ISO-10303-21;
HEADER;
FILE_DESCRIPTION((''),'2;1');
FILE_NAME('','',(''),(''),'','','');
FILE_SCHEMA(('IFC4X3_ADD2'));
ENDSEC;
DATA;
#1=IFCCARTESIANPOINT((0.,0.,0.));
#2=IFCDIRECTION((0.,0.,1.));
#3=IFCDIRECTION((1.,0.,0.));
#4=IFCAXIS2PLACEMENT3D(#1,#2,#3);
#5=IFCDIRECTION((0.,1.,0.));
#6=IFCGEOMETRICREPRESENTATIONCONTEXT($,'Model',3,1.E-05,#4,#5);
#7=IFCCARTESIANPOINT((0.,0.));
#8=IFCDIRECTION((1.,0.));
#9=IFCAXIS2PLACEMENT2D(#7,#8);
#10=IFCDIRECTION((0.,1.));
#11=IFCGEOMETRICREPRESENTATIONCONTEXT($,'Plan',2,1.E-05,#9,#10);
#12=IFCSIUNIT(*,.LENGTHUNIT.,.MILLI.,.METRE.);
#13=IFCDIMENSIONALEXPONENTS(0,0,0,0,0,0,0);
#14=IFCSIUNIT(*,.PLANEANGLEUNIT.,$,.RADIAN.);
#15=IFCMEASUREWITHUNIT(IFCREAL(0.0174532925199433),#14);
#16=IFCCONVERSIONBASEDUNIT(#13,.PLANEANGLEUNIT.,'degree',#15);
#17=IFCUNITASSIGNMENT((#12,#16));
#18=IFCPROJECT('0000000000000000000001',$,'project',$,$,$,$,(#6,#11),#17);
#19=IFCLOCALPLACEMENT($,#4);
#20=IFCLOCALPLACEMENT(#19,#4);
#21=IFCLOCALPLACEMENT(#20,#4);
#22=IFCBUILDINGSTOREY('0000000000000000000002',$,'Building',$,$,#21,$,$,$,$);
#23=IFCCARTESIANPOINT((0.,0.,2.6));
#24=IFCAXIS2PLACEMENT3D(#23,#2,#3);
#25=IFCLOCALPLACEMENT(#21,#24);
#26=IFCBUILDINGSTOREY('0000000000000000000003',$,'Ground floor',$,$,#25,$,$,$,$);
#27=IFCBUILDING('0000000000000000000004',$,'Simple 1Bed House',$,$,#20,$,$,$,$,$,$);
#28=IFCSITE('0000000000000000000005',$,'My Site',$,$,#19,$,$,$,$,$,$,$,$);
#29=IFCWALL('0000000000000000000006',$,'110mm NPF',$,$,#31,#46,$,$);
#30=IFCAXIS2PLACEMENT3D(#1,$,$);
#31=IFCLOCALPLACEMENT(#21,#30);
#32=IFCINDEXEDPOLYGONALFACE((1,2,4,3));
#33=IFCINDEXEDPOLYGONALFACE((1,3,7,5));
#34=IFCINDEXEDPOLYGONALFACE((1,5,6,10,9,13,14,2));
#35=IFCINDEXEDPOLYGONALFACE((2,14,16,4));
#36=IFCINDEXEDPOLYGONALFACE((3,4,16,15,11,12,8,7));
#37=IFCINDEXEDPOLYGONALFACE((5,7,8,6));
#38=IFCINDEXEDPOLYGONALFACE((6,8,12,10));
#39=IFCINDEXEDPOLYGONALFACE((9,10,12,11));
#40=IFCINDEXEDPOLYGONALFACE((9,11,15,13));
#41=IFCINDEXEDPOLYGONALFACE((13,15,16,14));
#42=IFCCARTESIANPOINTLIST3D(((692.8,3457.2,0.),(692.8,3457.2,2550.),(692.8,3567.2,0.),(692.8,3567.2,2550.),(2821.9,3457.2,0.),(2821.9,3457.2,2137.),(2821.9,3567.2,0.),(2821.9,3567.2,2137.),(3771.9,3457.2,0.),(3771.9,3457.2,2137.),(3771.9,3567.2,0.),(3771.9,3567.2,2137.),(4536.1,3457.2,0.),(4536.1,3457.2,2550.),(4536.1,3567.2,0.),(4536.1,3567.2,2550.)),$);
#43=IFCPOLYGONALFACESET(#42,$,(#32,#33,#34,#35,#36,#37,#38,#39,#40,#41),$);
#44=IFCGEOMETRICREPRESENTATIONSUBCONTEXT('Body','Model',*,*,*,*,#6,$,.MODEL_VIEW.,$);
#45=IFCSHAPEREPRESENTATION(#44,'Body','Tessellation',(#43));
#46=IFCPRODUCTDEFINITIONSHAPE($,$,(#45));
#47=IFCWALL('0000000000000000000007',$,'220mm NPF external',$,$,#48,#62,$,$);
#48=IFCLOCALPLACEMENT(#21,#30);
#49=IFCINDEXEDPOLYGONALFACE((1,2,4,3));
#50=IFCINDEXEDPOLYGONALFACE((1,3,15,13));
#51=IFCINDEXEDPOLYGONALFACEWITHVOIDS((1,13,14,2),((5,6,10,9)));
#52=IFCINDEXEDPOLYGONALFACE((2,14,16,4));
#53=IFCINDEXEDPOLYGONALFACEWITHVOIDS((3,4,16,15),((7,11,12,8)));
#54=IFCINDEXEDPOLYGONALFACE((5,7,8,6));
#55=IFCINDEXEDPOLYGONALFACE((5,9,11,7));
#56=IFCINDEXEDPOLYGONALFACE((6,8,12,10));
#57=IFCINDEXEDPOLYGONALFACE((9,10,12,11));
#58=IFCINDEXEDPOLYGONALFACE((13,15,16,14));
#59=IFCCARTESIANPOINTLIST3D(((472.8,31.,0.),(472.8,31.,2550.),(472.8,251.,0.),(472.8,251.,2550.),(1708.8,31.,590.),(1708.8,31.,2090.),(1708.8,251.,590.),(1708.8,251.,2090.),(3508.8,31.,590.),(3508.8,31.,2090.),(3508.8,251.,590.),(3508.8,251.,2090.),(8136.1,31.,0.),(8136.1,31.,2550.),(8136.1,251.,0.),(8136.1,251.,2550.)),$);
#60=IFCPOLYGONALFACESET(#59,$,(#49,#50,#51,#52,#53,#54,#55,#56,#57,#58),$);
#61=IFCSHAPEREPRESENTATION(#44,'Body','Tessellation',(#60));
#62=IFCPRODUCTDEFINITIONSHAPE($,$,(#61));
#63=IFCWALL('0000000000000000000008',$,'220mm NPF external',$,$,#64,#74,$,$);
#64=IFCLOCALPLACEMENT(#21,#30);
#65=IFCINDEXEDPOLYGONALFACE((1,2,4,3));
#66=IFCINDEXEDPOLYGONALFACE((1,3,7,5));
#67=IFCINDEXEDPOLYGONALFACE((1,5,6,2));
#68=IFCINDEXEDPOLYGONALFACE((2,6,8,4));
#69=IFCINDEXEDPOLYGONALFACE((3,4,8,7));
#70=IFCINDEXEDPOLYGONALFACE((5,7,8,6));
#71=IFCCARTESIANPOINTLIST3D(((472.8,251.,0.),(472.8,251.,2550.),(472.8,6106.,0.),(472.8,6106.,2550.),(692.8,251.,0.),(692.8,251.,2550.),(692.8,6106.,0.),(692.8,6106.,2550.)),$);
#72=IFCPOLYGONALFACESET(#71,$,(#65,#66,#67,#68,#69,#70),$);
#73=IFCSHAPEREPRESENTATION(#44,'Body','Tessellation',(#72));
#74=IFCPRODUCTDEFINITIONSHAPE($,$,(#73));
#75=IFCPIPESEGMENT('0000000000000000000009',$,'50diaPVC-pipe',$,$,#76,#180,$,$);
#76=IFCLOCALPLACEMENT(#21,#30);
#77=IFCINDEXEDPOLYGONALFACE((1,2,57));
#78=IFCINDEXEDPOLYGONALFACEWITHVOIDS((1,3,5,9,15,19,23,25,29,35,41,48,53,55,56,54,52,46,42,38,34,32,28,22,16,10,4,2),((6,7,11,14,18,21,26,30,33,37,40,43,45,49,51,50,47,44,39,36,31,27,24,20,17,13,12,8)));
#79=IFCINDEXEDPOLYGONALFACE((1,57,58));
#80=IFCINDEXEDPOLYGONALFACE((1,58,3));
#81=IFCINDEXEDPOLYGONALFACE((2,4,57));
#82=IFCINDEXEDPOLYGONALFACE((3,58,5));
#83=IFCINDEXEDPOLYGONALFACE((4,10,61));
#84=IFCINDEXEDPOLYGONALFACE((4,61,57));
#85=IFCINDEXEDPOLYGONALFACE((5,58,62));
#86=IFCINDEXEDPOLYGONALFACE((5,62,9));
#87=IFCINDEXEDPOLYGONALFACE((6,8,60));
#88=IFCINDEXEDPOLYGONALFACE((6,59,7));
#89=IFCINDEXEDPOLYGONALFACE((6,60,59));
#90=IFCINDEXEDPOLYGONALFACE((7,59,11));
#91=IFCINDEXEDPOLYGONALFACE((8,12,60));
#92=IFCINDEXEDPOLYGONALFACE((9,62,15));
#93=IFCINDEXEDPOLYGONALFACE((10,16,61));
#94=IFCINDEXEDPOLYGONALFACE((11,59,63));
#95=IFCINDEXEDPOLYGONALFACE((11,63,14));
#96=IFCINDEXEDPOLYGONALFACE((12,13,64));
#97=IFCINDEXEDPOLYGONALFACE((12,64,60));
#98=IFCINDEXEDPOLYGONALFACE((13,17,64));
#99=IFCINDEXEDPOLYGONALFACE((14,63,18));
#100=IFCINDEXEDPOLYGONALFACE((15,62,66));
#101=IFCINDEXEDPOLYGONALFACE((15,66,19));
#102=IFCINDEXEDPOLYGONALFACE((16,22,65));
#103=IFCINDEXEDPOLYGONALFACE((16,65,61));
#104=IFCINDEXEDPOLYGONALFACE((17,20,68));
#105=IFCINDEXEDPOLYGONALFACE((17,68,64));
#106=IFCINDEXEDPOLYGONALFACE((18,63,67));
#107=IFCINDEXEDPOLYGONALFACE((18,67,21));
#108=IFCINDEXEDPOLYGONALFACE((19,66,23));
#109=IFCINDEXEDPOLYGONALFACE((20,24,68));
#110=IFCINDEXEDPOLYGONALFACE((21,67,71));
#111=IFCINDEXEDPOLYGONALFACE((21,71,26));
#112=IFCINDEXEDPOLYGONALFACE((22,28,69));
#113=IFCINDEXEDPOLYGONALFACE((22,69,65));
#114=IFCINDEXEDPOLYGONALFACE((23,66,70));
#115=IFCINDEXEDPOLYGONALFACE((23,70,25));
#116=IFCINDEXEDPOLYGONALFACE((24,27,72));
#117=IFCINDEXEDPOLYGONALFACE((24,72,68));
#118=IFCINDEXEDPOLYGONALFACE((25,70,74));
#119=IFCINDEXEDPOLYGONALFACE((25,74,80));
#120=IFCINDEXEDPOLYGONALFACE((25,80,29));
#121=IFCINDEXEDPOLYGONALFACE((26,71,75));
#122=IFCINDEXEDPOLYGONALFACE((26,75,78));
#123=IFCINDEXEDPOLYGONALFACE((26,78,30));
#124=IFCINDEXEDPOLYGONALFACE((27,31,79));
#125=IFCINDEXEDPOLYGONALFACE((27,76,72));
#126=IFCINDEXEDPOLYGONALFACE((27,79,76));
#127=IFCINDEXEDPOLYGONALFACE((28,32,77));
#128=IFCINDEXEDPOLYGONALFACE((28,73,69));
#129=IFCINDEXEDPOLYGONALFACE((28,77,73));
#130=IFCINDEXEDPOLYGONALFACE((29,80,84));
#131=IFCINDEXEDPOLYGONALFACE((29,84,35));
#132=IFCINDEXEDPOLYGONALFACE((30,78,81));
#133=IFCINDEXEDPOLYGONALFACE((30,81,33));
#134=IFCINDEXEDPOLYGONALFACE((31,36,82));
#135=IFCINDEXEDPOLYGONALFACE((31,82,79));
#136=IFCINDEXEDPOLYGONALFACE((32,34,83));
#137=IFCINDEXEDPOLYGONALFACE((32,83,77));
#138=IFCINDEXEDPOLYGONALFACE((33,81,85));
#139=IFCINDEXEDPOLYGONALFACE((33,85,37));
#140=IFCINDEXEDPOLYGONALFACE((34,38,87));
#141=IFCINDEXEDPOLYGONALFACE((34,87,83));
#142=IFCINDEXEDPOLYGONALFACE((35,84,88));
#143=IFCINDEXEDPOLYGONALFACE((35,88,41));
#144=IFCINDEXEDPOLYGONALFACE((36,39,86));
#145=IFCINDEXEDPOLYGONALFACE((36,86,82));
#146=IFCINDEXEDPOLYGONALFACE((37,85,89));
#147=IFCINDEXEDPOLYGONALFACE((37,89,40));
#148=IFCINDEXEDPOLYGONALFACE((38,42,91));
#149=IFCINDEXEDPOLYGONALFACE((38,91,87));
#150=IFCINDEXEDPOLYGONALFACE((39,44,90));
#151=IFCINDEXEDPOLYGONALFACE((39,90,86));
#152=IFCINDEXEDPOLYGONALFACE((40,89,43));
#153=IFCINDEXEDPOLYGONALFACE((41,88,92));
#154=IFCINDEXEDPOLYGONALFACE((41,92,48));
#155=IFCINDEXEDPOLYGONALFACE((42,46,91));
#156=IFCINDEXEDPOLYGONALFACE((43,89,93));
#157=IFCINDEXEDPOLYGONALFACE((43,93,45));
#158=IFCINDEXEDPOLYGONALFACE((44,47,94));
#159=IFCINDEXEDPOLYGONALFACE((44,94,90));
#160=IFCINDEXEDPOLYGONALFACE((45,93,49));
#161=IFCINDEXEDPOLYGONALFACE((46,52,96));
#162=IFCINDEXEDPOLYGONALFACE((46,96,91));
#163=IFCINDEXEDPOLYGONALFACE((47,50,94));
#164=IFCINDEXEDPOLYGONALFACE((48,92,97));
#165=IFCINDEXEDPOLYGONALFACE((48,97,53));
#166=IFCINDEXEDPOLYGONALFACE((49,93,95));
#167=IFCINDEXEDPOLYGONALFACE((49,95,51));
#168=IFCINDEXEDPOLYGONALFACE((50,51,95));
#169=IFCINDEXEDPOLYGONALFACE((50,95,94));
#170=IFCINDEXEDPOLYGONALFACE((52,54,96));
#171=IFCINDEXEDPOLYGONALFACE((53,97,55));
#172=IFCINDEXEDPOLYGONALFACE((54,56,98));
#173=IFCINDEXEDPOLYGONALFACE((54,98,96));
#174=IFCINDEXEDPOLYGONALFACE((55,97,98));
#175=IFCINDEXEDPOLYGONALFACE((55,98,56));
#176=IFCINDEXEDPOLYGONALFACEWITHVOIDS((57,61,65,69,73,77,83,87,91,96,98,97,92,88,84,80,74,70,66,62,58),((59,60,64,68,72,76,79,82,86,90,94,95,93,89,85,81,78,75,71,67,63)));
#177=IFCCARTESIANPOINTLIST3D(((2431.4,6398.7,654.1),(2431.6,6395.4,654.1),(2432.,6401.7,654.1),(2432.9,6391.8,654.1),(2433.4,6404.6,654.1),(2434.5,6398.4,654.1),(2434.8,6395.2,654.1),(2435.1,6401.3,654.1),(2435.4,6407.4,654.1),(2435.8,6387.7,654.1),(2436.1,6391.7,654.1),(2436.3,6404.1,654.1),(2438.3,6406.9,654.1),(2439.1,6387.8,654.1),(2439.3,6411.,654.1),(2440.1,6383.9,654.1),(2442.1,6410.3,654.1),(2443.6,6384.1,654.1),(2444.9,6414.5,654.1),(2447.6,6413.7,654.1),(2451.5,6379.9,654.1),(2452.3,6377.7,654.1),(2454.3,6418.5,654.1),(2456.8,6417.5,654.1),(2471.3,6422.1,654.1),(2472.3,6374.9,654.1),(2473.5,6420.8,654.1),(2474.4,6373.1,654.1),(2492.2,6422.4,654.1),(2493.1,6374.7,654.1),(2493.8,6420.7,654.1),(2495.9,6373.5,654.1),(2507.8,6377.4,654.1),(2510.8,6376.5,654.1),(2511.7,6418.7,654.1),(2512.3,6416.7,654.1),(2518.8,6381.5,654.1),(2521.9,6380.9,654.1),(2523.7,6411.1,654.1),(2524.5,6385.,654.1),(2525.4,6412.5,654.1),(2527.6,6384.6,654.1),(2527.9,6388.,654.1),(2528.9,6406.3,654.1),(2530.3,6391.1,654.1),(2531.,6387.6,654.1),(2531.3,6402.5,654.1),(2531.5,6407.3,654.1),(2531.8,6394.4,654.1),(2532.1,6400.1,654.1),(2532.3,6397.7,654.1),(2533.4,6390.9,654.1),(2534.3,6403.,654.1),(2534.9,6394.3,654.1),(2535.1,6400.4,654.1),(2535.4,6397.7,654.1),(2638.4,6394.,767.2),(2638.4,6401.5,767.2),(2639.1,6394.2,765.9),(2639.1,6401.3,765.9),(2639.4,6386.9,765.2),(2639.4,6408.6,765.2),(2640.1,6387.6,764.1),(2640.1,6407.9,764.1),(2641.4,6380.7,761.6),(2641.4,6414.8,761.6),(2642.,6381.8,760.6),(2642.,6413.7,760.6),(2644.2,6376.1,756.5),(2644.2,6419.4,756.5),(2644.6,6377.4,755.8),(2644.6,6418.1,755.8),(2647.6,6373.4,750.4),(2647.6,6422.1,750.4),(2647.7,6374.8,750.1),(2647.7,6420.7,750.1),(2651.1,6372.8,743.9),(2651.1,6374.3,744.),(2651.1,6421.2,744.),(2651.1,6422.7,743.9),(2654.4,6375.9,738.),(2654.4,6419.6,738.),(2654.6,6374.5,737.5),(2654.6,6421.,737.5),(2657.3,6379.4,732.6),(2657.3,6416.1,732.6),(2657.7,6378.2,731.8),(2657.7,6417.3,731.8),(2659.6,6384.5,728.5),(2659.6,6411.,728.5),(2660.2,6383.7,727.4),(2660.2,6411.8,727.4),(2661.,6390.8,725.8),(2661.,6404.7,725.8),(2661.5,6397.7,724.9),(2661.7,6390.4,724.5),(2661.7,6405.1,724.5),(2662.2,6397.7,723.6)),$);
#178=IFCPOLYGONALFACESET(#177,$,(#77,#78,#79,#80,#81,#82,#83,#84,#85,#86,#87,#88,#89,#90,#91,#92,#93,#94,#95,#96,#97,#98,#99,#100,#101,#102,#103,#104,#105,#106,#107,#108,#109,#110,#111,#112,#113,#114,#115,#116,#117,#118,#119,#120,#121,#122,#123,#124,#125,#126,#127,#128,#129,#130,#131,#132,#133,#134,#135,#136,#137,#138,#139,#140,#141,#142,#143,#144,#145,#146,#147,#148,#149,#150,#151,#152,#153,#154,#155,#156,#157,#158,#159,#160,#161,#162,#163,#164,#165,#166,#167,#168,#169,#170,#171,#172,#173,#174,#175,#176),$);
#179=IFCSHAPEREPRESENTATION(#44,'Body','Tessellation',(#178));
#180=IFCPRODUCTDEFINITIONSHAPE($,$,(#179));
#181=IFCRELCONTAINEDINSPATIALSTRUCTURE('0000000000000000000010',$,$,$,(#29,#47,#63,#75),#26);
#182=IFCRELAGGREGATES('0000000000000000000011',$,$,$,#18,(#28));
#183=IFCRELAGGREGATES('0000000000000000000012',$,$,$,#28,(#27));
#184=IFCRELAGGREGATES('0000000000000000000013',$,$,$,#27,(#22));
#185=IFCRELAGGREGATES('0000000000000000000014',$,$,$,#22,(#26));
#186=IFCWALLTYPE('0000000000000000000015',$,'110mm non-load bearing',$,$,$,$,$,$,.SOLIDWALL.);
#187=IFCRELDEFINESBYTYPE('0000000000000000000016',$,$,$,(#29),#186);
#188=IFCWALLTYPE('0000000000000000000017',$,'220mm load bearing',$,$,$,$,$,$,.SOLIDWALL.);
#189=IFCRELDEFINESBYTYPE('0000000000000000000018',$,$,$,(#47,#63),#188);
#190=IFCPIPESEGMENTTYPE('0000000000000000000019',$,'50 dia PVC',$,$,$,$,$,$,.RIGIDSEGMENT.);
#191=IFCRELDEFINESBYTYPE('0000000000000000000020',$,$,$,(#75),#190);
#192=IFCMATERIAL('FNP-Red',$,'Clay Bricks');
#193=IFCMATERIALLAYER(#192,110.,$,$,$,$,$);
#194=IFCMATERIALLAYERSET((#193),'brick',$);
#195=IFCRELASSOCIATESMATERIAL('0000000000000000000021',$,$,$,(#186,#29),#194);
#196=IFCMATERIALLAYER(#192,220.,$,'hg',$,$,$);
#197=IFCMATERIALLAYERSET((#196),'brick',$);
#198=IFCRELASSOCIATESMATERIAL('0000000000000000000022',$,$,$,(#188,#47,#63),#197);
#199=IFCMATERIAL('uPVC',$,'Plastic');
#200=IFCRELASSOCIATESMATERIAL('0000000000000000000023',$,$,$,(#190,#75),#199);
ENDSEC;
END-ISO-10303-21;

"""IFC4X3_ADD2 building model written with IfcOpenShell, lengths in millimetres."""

from ifc_helpers import new_model, entity, si_unit, converted_unit, direction, frame, origin_with_axes, origin_2d_with_axis, place, context, subcontext, project, spatial, line, indexed_curve, hollow_circle, outline, extrude, clip, halfspace, source, transform, mapped, material, layer, layer_set, layer_usage, material_profile, profile_set, profile_usage, type_object, element, save


model = new_model("IFC4X3_ADD2")

# Units and contexts
model_context = context("Model", 3, precision=1e-05, world=origin_with_axes(), true_north=direction((0.0, 1.0, 0.0)))
plan_context = context("Plan", 2, precision=1e-05, world=origin_2d_with_axis(), true_north=direction((0.0, 1.0)))
body_context_1 = subcontext(model_context, "Body", "Model", "MODEL_VIEW")
ifc_project = project(units=[si_unit("LENGTHUNIT", "METRE", prefix="MILLI"), converted_unit("PLANEANGLEUNIT", "degree", entity("IfcReal", 0.0174532925199433), si_unit("PLANEANGLEUNIT", "RADIAN"), dimensions=[0, 0, 0, 0, 0, 0, 0])], contexts=[model_context, plan_context])

# Site, building, storeys
site_placement = place(None, origin_with_axes())
site = spatial("IfcSite", under=ifc_project, at=site_placement, Name="My Site")
building_placement = place(site_placement, origin_with_axes())
building = spatial("IfcBuilding", under=site, at=building_placement, Name="Simple 1Bed House")
storey_1_placement = place(building_placement, origin_with_axes())
storey_1 = spatial("IfcBuildingStorey", under=building, at=storey_1_placement, Name="Building")
storey_2_placement = place(storey_1_placement, frame((0.0, 0.0, 2.6), z_axis=(0.0, 0.0, 1.0), x_axis=(1.0, 0.0, 0.0)))
storey_2 = spatial("IfcBuildingStorey", under=storey_1, at=storey_2_placement, Name="Ground floor")

# Walls, openings
ifc_material_1 = material(Name="FNP-Red", Category="Clay Bricks")
ifc_layer_1 = layer(ifc_material_1, 110.0)
ifc_layer_set_1 = layer_set([ifc_layer_1], Name="brick")
ifc_layer_usage_1 = layer_usage(ifc_layer_set_1, "AXIS2", "POSITIVE", 0.0)
wall_type_1 = type_object("IfcWallType", Name="110mm non-load bearing", PredefinedType="SOLIDWALL", material=ifc_layer_set_1)
wall_1_placement = place(storey_2_placement, frame((692.8, 3457.2, -2.6), z_axis=(0.0, 0.0, 1.0), x_axis=(1.0, 0.000001, 0.0)))
wall_1 = element("IfcWall", 1, at=wall_1_placement, inside=storey_2, type_object=wall_type_1, material=ifc_layer_usage_1, Name="110mm NPF", context=body_context_1, shape_type="SweptSolid", body=[
    extrude(outline(indexed_curve([(0.0, 0.0), (0.0, 110.0), (3843.3, 110.0), (3843.3, 0.0), (0.0, 0.0)], self_intersect=False)), origin_with_axes(), (0.0, 0.0, 1.0), 2550.0),
])
shared_shape_1 = source(origin_with_axes(), body_context_1, "Body", "SweptSolid", [
    extrude(outline(indexed_curve([(0.0, 2137.0), (0.0, 0.0), (950.0, 0.0), (950.0, 2137.0), (0.0, 2137.0)])), frame((0.0, -600.0, 0.0), z_axis=(0.0, -1.0, 0.0), x_axis=(1.0, 0.0, 0.0)), (0.0, 0.0, -1.0), 1200.0),
])
opening_1_placement = place(wall_1_placement, frame((3079.1, 120.0, 0.0), z_axis=(0.0, 0.0, 1.0), x_axis=(-1.0, 0.0, 0.0)))
element("IfcOpeningElement", 2, at=opening_1_placement, cuts=wall_1, PredefinedType="OPENING", context=body_context_1, shape_type="MappedRepresentation", body=[
    mapped(shared_shape_1, transform((0.0, 0.0, 0.0), x_axis=(1.0, 0.0, 0.0), y_axis=(0.0, 1.0, 0.0), z_axis=(0.0, 0.0, 1.0), scale=1.0)),
])
ifc_layer_2 = layer(ifc_material_1, 220.0, Name="hg")
ifc_layer_set_2 = layer_set([ifc_layer_2], Name="brick")
ifc_layer_usage_2 = layer_usage(ifc_layer_set_2, "AXIS2", "POSITIVE", 0.0)
wall_type_2 = type_object("IfcWallType", Name="220mm load bearing", PredefinedType="SOLIDWALL", material=ifc_layer_set_2)
wall_2_placement = place(storey_2_placement, frame((472.8, 31.0, -2.6), z_axis=(0.0, 0.0, 1.0), x_axis=(1.0, 0.0, 0.0)))
wall_2 = element("IfcWall", 3, at=wall_2_placement, inside=storey_2, type_object=wall_type_2, material=ifc_layer_usage_2, Name="220mm NPF external", context=body_context_1, shape_type="SweptSolid", body=[
    extrude(outline(indexed_curve([(0.0, 0.0), (0.0, 220.0), (7663.3, 220.0), (7663.3, 0.0), (0.0, 0.0)], self_intersect=False)), origin_with_axes(), (0.0, 0.0, 1.0), 2550.0),
])
shared_shape_2 = source(origin_with_axes(), body_context_1, "Body", "SweptSolid", [
    extrude(outline(indexed_curve([(0.0, 0.0), (1800.0, 0.0), (1800.0, 1500.0), (0.0, 1500.0)], segments=[line(1, 2, 3, 4, 1)])), frame((0.0, -600.0, 0.0), z_axis=(0.0, -1.0, 0.0), x_axis=(1.0, 0.0, 0.0)), (0.0, 0.0, -1.0), 1200.0),
])
opening_2_placement = place(wall_2_placement, frame((1236.0, -25.6, 590.0), z_axis=(0.0, 0.0, 1.0), x_axis=(1.0, 0.0, 0.0)))
element("IfcOpeningElement", 4, at=opening_2_placement, cuts=wall_2, PredefinedType="OPENING", context=body_context_1, shape_type="MappedRepresentation", body=[
    mapped(shared_shape_2, transform((0.0, 0.0, 0.0), x_axis=(1.0, 0.0, 0.0), y_axis=(0.0, 1.0, 0.0), z_axis=(0.0, 0.0, 1.0), scale=1.0)),
])

# Wall
ifc_layer_usage_3 = layer_usage(ifc_layer_set_2, "AXIS2", "POSITIVE", 0.0)
wall_3_placement = place(storey_2_placement, frame((692.8, 251.0, -2.6), z_axis=(0.0, 0.0, 1.0), x_axis=(0.0, 1.0, 0.0)))
element("IfcWall", 5, at=wall_3_placement, inside=storey_2, type_object=wall_type_2, material=ifc_layer_usage_3, Name="220mm NPF external", context=body_context_1, shape_type="SweptSolid", body=[
    extrude(outline(indexed_curve([(0.0, 0.0), (0.0, 220.0), (5855.0, 220.0), (5855.0, 0.0), (0.0, 0.0)], self_intersect=False)), origin_with_axes(), (0.0, 0.0, 1.0), 2550.0),
])

# Pipe segment
ifc_material_2 = material(Name="uPVC", Category="Plastic")
ifc_material_profile_1 = material_profile(ifc_material_2, hollow_circle(Radius=25.0, WallThickness=1.5))
ifc_profile_set_1 = profile_set([ifc_material_profile_1])
pipe_segment_type_1 = type_object("IfcPipeSegmentType", Name="50 dia PVC", PredefinedType="RIGIDSEGMENT", material=ifc_profile_set_1)
ifc_profile_usage_1 = profile_usage(ifc_profile_set_1, cardinal=5)
pipe_segment_1_placement = place(storey_2_placement, frame((2650.2, 6397.7, 742.9), z_axis=(-0.876967, 0.0, -0.480551), x_axis=(0.480551, 0.0, -0.876967)))
element("IfcPipeSegment", 6, at=pipe_segment_1_placement, inside=storey_2, type_object=pipe_segment_type_1, material=ifc_profile_usage_1, Name="50diaPVC-pipe", context=body_context_1, shape_type="Clipping", body=[
    clip(extrude(hollow_circle(Radius=25.0, WallThickness=1.5), origin_with_axes(), (0.0, 0.0, 1.0), 240.2), halfspace(frame((-953.5, -12.6, 1930.3), z_axis=(0.876967, 0.0, 0.480551), x_axis=(0.0, -1.0, 0.0)), False)),
])

save(model, "model.ifc")
